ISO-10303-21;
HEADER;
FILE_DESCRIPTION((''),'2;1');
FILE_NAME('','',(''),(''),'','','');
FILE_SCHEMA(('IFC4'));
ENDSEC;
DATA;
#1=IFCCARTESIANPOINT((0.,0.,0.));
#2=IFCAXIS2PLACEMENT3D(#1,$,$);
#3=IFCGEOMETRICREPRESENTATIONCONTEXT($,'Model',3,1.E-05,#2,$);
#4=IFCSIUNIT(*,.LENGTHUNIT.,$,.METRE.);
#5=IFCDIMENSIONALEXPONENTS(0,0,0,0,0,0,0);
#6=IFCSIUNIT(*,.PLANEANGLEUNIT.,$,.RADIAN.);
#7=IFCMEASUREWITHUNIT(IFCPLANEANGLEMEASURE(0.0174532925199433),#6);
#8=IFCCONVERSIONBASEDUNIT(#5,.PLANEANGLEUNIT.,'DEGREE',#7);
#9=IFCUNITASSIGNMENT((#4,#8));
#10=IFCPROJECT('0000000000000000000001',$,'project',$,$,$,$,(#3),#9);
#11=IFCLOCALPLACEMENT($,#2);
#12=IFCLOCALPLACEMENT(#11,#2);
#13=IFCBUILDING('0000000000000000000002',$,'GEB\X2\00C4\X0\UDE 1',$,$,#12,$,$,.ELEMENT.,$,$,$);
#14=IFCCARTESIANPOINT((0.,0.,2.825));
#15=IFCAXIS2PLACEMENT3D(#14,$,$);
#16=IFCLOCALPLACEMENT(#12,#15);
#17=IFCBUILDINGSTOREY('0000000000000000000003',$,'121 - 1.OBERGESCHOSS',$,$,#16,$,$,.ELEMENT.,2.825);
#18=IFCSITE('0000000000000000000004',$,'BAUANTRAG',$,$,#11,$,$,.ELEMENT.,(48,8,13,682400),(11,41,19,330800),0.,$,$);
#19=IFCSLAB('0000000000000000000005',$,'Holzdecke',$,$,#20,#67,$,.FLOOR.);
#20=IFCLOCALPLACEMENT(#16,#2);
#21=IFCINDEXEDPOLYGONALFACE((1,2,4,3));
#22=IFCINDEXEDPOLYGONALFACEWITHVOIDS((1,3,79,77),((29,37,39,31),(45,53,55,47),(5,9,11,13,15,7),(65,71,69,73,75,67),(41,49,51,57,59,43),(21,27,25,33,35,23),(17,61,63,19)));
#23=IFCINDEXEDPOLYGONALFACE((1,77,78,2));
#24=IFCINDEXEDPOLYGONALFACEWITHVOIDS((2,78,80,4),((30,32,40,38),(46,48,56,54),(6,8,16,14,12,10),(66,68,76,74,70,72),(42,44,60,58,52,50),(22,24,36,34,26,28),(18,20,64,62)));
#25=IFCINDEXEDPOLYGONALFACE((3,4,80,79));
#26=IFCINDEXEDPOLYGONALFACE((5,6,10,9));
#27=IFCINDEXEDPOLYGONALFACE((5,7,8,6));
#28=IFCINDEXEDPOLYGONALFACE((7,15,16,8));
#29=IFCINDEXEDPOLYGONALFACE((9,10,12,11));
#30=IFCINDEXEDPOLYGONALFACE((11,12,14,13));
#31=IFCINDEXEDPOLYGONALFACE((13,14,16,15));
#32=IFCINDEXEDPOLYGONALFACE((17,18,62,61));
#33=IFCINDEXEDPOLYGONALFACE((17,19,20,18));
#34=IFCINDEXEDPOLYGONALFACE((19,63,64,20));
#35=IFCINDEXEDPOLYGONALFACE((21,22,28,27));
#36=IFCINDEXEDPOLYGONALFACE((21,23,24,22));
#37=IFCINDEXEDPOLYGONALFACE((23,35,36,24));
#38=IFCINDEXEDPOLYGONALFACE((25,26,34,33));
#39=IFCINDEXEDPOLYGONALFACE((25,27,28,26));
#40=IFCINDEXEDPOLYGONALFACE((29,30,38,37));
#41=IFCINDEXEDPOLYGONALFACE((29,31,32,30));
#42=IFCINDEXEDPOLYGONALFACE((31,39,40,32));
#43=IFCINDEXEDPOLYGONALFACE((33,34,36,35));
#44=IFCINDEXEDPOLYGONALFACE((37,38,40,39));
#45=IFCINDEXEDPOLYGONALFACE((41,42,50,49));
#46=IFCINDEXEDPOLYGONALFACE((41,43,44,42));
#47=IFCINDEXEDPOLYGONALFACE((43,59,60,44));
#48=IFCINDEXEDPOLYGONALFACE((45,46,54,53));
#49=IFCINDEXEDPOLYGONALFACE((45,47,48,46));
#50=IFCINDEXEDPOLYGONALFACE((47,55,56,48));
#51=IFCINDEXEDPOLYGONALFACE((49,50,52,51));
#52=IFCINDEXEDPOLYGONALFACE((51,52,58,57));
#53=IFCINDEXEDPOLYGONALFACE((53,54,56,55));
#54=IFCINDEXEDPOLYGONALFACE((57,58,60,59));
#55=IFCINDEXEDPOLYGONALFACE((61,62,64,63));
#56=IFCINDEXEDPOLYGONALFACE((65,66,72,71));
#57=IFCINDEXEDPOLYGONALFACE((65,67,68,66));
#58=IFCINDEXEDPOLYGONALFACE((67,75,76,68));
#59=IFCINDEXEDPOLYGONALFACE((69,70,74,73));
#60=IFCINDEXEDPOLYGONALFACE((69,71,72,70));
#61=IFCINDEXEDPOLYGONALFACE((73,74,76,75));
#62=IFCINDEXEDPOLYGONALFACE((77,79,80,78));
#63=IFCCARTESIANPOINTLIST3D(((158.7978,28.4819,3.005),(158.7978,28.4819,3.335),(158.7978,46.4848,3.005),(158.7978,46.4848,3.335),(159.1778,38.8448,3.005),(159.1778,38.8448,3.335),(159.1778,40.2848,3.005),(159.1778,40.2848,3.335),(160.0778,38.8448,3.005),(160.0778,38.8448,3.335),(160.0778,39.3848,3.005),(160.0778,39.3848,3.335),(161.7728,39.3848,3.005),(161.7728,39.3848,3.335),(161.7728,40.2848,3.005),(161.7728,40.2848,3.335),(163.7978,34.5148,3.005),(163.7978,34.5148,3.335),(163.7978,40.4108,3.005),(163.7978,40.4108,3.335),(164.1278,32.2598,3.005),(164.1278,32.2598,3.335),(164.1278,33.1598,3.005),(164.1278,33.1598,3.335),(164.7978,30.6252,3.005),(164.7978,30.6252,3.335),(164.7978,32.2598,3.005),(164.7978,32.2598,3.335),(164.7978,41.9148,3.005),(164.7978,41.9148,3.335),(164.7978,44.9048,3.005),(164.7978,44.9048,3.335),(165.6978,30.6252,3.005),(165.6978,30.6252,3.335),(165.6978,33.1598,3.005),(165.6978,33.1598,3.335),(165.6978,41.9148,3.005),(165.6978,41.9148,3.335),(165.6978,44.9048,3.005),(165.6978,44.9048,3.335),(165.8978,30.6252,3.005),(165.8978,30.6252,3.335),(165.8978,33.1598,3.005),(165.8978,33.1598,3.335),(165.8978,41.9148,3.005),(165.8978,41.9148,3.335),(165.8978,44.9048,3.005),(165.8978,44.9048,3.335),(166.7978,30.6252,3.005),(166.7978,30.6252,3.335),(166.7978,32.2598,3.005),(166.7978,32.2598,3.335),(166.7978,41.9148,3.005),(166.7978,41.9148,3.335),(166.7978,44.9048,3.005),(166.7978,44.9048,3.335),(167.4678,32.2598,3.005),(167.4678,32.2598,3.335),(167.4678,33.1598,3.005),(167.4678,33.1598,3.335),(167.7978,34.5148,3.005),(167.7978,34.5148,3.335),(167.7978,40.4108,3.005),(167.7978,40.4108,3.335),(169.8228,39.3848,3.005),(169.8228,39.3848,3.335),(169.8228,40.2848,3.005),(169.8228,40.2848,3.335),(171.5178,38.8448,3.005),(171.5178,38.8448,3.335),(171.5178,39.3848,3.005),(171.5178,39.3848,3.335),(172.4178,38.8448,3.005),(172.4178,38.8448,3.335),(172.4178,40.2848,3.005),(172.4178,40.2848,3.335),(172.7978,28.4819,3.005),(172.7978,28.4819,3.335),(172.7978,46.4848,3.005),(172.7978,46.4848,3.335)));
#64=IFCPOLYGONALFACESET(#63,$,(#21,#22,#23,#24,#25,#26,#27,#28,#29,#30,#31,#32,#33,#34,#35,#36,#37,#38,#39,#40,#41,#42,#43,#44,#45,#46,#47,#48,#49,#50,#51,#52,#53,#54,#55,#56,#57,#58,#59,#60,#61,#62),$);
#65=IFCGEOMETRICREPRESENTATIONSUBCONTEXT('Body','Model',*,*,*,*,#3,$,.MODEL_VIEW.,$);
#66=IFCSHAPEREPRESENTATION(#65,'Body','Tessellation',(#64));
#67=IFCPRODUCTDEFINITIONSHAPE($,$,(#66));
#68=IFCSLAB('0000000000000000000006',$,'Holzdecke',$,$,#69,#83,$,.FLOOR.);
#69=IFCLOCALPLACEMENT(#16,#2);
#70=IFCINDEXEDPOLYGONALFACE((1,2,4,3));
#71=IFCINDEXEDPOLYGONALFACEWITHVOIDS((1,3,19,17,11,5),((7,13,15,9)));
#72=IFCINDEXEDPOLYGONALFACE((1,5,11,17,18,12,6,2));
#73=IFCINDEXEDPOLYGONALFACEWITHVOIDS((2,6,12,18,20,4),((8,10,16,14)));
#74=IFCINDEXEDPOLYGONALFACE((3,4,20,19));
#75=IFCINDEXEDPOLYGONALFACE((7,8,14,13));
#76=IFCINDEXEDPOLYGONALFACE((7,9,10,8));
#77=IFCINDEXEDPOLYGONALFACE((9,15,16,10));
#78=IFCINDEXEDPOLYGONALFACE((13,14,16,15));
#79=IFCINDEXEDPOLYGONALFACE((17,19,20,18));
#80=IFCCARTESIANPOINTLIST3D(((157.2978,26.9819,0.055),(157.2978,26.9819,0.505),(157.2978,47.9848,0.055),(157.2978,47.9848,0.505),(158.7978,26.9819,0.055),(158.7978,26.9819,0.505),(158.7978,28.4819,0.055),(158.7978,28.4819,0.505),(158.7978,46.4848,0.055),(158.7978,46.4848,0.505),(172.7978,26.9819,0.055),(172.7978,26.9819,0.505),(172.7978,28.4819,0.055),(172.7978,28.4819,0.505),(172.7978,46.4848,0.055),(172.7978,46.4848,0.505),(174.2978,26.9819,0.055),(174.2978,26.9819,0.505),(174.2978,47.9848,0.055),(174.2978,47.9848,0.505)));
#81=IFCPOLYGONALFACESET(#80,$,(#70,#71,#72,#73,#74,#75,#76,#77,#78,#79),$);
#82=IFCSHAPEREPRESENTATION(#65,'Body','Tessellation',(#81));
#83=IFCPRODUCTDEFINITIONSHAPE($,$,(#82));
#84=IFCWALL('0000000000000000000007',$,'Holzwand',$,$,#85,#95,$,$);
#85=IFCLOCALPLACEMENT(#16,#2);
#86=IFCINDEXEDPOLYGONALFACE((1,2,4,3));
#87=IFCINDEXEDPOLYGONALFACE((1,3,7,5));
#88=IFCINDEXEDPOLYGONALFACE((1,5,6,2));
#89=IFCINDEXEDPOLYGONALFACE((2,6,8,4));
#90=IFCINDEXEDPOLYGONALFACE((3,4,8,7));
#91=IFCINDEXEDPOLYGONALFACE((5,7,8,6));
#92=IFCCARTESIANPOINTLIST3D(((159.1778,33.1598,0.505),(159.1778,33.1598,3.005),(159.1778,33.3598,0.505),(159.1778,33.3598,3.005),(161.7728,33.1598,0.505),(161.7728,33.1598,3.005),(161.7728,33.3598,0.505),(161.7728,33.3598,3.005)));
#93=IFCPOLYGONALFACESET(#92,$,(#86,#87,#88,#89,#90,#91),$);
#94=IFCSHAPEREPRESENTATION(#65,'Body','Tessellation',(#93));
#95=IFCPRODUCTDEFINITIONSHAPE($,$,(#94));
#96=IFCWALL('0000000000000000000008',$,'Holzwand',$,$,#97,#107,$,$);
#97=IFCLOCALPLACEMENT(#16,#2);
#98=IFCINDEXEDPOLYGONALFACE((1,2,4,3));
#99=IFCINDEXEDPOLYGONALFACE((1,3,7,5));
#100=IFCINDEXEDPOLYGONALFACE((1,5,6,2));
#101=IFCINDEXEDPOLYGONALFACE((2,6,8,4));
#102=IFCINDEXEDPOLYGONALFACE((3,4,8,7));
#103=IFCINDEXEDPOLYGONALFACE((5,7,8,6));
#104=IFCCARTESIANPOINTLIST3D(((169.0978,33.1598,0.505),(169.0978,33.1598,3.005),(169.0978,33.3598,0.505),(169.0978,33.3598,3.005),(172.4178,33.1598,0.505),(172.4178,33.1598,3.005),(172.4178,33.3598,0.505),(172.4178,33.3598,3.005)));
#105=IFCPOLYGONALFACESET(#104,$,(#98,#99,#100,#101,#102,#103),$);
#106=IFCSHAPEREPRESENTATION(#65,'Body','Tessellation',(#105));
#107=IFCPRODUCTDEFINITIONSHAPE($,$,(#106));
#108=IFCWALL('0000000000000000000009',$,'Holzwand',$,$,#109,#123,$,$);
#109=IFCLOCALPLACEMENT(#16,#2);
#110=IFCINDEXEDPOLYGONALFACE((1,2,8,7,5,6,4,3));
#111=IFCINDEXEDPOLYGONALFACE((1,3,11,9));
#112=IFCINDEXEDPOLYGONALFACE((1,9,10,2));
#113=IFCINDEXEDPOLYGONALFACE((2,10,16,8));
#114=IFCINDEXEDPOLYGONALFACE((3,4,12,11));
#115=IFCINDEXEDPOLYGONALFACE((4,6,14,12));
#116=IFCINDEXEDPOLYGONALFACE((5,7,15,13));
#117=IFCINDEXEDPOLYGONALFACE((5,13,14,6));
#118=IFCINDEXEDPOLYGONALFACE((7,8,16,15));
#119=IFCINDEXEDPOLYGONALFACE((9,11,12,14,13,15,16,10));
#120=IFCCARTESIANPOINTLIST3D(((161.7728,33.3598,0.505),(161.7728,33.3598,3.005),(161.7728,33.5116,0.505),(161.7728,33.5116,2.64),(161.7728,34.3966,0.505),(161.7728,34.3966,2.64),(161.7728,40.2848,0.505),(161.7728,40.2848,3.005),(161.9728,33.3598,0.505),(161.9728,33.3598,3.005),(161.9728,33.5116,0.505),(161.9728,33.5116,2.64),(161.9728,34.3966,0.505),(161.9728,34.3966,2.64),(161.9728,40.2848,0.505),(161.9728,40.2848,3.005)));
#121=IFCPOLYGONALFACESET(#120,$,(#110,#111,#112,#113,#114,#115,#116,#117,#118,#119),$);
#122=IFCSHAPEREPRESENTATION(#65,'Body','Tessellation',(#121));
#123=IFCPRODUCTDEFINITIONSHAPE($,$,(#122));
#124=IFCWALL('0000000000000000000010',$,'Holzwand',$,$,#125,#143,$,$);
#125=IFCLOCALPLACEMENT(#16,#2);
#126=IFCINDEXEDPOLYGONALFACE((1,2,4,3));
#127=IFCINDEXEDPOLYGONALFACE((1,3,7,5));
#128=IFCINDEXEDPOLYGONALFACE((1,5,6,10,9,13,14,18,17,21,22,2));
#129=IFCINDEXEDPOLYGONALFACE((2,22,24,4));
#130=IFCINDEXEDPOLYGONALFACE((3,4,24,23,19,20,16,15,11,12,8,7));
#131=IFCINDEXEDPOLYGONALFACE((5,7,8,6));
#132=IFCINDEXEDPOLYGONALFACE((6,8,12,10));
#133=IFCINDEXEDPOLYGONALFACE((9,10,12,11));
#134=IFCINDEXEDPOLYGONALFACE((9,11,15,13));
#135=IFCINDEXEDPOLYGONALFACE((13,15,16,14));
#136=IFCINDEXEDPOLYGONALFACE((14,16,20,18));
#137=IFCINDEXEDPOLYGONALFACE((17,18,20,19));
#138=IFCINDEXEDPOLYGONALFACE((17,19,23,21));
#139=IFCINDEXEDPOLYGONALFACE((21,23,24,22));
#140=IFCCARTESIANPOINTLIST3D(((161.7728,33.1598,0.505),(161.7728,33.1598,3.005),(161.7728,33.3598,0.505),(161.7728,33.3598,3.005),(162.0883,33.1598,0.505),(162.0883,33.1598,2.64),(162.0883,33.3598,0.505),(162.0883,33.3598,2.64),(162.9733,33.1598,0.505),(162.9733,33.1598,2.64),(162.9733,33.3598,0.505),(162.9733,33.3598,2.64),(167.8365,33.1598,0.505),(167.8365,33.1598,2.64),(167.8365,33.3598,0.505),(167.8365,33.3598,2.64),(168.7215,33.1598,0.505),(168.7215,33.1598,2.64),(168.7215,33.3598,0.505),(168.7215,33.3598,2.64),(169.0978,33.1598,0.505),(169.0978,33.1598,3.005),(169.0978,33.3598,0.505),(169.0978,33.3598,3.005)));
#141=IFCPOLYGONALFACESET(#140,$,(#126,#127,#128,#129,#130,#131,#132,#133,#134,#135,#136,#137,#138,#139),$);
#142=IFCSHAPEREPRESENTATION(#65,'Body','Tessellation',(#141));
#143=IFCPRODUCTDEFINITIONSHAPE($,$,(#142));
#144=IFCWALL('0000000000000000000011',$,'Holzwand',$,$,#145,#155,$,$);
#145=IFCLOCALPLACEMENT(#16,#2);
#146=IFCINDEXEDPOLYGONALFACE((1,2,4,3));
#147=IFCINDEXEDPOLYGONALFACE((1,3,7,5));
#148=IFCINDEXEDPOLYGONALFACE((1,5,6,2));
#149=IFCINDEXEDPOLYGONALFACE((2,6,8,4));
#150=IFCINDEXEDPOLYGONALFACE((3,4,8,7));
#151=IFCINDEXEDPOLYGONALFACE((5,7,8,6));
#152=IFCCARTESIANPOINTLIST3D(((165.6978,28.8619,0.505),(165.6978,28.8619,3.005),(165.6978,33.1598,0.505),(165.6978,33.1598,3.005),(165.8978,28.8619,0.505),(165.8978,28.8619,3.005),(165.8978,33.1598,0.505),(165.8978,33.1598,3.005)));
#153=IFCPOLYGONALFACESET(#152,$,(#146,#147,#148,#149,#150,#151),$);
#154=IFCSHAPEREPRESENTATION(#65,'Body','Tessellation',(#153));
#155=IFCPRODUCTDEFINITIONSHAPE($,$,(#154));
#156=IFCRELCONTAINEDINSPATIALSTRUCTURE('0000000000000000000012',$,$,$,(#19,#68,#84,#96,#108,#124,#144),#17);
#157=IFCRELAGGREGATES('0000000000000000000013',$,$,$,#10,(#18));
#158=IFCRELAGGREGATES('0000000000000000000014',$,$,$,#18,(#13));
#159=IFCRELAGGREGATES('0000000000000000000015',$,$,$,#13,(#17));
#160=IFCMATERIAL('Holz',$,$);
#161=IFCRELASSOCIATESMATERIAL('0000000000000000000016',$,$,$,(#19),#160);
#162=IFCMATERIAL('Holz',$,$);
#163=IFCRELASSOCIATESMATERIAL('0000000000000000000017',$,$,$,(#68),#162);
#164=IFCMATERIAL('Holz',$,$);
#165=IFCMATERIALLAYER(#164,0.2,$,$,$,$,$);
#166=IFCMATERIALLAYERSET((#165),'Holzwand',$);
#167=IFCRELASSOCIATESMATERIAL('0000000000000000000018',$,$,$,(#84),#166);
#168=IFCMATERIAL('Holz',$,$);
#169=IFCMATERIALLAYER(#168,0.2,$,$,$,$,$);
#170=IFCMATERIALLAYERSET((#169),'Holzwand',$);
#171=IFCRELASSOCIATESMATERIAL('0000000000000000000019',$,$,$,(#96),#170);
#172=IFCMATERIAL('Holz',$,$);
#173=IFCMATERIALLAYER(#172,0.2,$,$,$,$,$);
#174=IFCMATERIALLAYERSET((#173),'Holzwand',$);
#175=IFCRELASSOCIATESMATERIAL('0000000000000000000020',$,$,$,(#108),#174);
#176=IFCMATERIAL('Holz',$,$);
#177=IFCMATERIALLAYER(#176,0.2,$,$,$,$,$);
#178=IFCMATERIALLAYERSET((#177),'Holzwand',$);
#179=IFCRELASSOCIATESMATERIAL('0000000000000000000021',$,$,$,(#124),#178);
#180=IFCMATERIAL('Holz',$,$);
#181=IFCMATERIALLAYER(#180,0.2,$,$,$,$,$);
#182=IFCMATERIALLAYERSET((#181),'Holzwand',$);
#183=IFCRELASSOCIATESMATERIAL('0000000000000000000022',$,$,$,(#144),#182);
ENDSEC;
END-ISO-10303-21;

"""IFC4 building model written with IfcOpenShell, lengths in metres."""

from ifc_helpers import new_model, entity, si_unit, converted_unit, frame, frame_2d, origin, origin_with_axes, place, context, subcontext, project, spatial, polyline, rectangle, outline, extrude, material, layer, layer_set, layer_usage, element, save


model = new_model("IFC4")

# Units and contexts
model_context = context("Model", 3, precision=1e-05, world=origin())
body_context = subcontext(model_context, "Body", "Model", "MODEL_VIEW")
ifc_project = project(units=[si_unit("LENGTHUNIT", "METRE"), converted_unit("PLANEANGLEUNIT", "DEGREE", entity("IfcPlaneAngleMeasure", 0.0174532925199433), si_unit("PLANEANGLEUNIT", "RADIAN"), dimensions=[0, 0, 0, 0, 0, 0, 0])], contexts=[model_context])

# Site, building, storey
site_placement = place(None, origin())
site = spatial("IfcSite", under=ifc_project, at=site_placement, Name="BAUANTRAG", CompositionType="ELEMENT", RefLatitude=(48, 8, 13, 682400), RefLongitude=(11, 41, 19, 330800), RefElevation=0.0)
building_placement = place(site_placement, origin())
building = spatial("IfcBuilding", under=site, at=building_placement, Name="GEBÄUDE 1", CompositionType="ELEMENT")
storey_placement = place(building_placement, frame((0.0, 0.0, 2.825)))
storey = spatial("IfcBuildingStorey", under=building, at=storey_placement, Name="121 - 1.OBERGESCHOSS", CompositionType="ELEMENT", Elevation=2.825)

# Slab, opening
ifc_material_1 = material(Name="Holz")
slab_1_placement = place(storey_placement, frame((158.7978, 28.4819, 3.005)))
slab_1 = element("IfcSlab", 1, at=slab_1_placement, inside=storey, material=ifc_material_1, Name="Holzdecke", PredefinedType="FLOOR", context=body_context, shape_type="SweptSolid", body=[
    extrude(outline(polyline([(0.0, 0.0), (14.0, 0.0), (14.0, 18.0029), (0.0, 18.0029), (0.0, 0.0)]), holes=[polyline([(9.0, 6.0329), (5.0, 6.0329), (5.0, 11.9289), (9.0, 11.9289), (9.0, 6.0329)]), polyline([(6.0, 2.1433), (6.0, 3.7779), (5.33, 3.7779), (5.33, 4.6779), (6.0, 4.6779), (6.9, 4.6779), (6.9, 2.1433), (6.0, 2.1433)]), polyline([(8.0, 2.1433), (7.1, 2.1433), (7.1, 4.6779), (8.0, 4.6779), (8.67, 4.6779), (8.67, 3.7779), (8.0, 3.7779), (8.0, 2.1433)]), polyline([(13.62, 10.3629), (12.72, 10.3629), (12.72, 10.9029), (11.025, 10.9029), (11.025, 11.8029), (13.62, 11.8029), (13.62, 10.3629)]), polyline([(7.1, 13.4329), (7.1, 16.4229), (8.0, 16.4229), (8.0, 13.4329), (7.1, 13.4329)]), polyline([(6.9, 13.4329), (6.0, 13.4329), (6.0, 16.4229), (6.9, 16.4229), (6.9, 13.4329)])]), origin_with_axes(), (0.0, 0.0, 1.0), 0.33),
])
opening_1_placement = place(slab_1_placement, frame((0.38, 10.3629, 0.0)))
element("IfcOpeningElement", 2, at=opening_1_placement, cuts=slab_1, ObjectType="Opening", context=body_context, shape_type="SweptSolid", body=[
    extrude(outline(polyline([(1.43, 0.78), (-1.165, 0.78), (-1.165, -0.66), (-0.265, -0.66), (-0.265, -0.12), (1.43, -0.12), (1.43, 0.78)])), frame((1.165, 0.66, 0.0), z_axis=(0.0, 0.0, 1.0), x_axis=(1.0, 0.0, 0.0)), (0.0, 0.0, 1.0), 0.33),
])

# Slab
ifc_material_2 = material(Name="Holz")
slab_2_placement = place(storey_placement, frame((157.2978, 26.9819, 0.055)))
element("IfcSlab", 3, at=slab_2_placement, inside=storey, material=ifc_material_2, Name="Holzdecke", PredefinedType="FLOOR", context=body_context, shape_type="SweptSolid", body=[
    extrude(outline(polyline([(17.0, 0.0), (17.0, 21.0029), (0.0, 21.0029), (0.0, 0.0), (1.5, 0.0), (15.5, 0.0), (17.0, 0.0)]), holes=[polyline([(15.5, 19.5029), (15.5, 1.5), (1.5, 1.5), (1.5, 19.5029), (15.5, 19.5029)])]), origin_with_axes(), (0.0, 0.0, 1.0), 0.45),
])

# Walls
ifc_material_3 = material(Name="Holz")
ifc_layer_1 = layer(ifc_material_3, 0.2)
ifc_layer_set_1 = layer_set([ifc_layer_1], Name="Holzwand")
ifc_layer_usage_1 = layer_usage(ifc_layer_set_1, "AXIS2", "POSITIVE", 0.0)
wall_1_placement = place(storey_placement, frame((159.1778, 33.1598, 0.505)))
element("IfcWall", 4, at=wall_1_placement, inside=storey, material=ifc_layer_usage_1, Name="Holzwand", context=body_context, shape_type="SweptSolid", body=[
    extrude(rectangle(XDim=2.595, YDim=0.2, at=frame_2d((1.2975, 0.1), x_axis=(1.0, 0.0))), origin_with_axes(), (0.0, 0.0, 1.0), 2.5),
])
ifc_material_4 = material(Name="Holz")
ifc_layer_2 = layer(ifc_material_4, 0.2)
ifc_layer_set_2 = layer_set([ifc_layer_2], Name="Holzwand")
ifc_layer_usage_2 = layer_usage(ifc_layer_set_2, "AXIS2", "POSITIVE", 0.0)
wall_2_placement = place(storey_placement, frame((169.0978, 33.1598, 0.505)))
element("IfcWall", 5, at=wall_2_placement, inside=storey, material=ifc_layer_usage_2, Name="Holzwand", context=body_context, shape_type="SweptSolid", body=[
    extrude(rectangle(XDim=3.32, YDim=0.2, at=frame_2d((1.66, 0.1), x_axis=(1.0, 0.0))), origin_with_axes(), (0.0, 0.0, 1.0), 2.5),
])

# Wall, opening
ifc_material_5 = material(Name="Holz")
ifc_layer_3 = layer(ifc_material_5, 0.2)
ifc_layer_set_3 = layer_set([ifc_layer_3], Name="Holzwand")
ifc_layer_usage_3 = layer_usage(ifc_layer_set_3, "AXIS2", "POSITIVE", 0.0)
wall_3_placement = place(storey_placement, frame((161.9728, 33.3598, 0.505), z_axis=(0.0, 0.0, 1.0), x_axis=(0.0, 1.0, 0.0)))
wall_3 = element("IfcWall", 6, at=wall_3_placement, inside=storey, material=ifc_layer_usage_3, Name="Holzwand", context=body_context, shape_type="SweptSolid", body=[
    extrude(rectangle(XDim=6.925, YDim=0.2, at=frame_2d((3.4625, 0.1), x_axis=(1.0, 0.0))), origin_with_axes(), (0.0, 0.0, 1.0), 2.5),
])
opening_2_placement = place(wall_3_placement, frame((1.0368, 0.2, -0.15), z_axis=(0.0, -1.0, 0.0), x_axis=(0.0, 0.0, 1.0)))
element("IfcOpeningElement", 7, at=opening_2_placement, cuts=wall_3, ObjectType="Opening", context=body_context, shape_type="SweptSolid", body=[
    extrude(outline(polyline([(0.0, 0.885), (2.285, 0.885), (2.285, 0.0), (0.0, 0.0), (0.0, 0.885)])), origin_with_axes(), (0.0, 0.0, 1.0), 0.2),
])

# Wall, openings
ifc_material_6 = material(Name="Holz")
ifc_layer_4 = layer(ifc_material_6, 0.2)
ifc_layer_set_4 = layer_set([ifc_layer_4], Name="Holzwand")
ifc_layer_usage_4 = layer_usage(ifc_layer_set_4, "AXIS2", "POSITIVE", 0.0)
wall_4_placement = place(storey_placement, frame((169.0978, 33.3598, 0.505), z_axis=(0.0, 0.0, 1.0), x_axis=(-1.0, 0.0, 0.0)))
wall_4 = element("IfcWall", 8, at=wall_4_placement, inside=storey, material=ifc_layer_usage_4, Name="Holzwand", context=body_context, shape_type="SweptSolid", body=[
    extrude(rectangle(XDim=7.325, YDim=0.2, at=frame_2d((3.6625, 0.1), x_axis=(1.0, 0.0))), origin_with_axes(), (0.0, 0.0, 1.0), 2.5),
])
opening_3_placement = place(wall_4_placement, frame((7.0095, 0.2, -0.15), z_axis=(0.0, -1.0, 0.0), x_axis=(0.0, 0.0, 1.0)))
element("IfcOpeningElement", 9, at=opening_3_placement, cuts=wall_4, ObjectType="Opening", context=body_context, shape_type="SweptSolid", body=[
    extrude(outline(polyline([(0.0, 0.885), (2.285, 0.885), (2.285, 0.0), (0.0, 0.0), (0.0, 0.885)])), origin_with_axes(), (0.0, 0.0, 1.0), 0.2),
])
opening_4_placement = place(wall_4_placement, frame((1.2613, 0.2, -0.15), z_axis=(0.0, -1.0, 0.0), x_axis=(0.0, 0.0, 1.0)))
element("IfcOpeningElement", 10, at=opening_4_placement, cuts=wall_4, ObjectType="Opening", context=body_context, shape_type="SweptSolid", body=[
    extrude(outline(polyline([(0.0, 0.885), (2.285, 0.885), (2.285, 0.0), (0.0, 0.0), (0.0, 0.885)])), origin_with_axes(), (0.0, 0.0, 1.0), 0.2),
])

# Wall
ifc_material_7 = material(Name="Holz")
ifc_layer_5 = layer(ifc_material_7, 0.2)
ifc_layer_set_5 = layer_set([ifc_layer_5], Name="Holzwand")
ifc_layer_usage_5 = layer_usage(ifc_layer_set_5, "AXIS2", "POSITIVE", 0.0)
wall_5_placement = place(storey_placement, frame((165.6978, 33.1598, 0.505), z_axis=(0.0, 0.0, 1.0), x_axis=(0.0, -1.0, 0.0)))
element("IfcWall", 11, at=wall_5_placement, inside=storey, material=ifc_layer_usage_5, Name="Holzwand", context=body_context, shape_type="SweptSolid", body=[
    extrude(rectangle(XDim=4.2979, YDim=0.2, at=frame_2d((2.1489, 0.1), x_axis=(1.0, 0.0))), origin_with_axes(), (0.0, 0.0, 1.0), 2.5),
])

save(model, "model.ifc")
